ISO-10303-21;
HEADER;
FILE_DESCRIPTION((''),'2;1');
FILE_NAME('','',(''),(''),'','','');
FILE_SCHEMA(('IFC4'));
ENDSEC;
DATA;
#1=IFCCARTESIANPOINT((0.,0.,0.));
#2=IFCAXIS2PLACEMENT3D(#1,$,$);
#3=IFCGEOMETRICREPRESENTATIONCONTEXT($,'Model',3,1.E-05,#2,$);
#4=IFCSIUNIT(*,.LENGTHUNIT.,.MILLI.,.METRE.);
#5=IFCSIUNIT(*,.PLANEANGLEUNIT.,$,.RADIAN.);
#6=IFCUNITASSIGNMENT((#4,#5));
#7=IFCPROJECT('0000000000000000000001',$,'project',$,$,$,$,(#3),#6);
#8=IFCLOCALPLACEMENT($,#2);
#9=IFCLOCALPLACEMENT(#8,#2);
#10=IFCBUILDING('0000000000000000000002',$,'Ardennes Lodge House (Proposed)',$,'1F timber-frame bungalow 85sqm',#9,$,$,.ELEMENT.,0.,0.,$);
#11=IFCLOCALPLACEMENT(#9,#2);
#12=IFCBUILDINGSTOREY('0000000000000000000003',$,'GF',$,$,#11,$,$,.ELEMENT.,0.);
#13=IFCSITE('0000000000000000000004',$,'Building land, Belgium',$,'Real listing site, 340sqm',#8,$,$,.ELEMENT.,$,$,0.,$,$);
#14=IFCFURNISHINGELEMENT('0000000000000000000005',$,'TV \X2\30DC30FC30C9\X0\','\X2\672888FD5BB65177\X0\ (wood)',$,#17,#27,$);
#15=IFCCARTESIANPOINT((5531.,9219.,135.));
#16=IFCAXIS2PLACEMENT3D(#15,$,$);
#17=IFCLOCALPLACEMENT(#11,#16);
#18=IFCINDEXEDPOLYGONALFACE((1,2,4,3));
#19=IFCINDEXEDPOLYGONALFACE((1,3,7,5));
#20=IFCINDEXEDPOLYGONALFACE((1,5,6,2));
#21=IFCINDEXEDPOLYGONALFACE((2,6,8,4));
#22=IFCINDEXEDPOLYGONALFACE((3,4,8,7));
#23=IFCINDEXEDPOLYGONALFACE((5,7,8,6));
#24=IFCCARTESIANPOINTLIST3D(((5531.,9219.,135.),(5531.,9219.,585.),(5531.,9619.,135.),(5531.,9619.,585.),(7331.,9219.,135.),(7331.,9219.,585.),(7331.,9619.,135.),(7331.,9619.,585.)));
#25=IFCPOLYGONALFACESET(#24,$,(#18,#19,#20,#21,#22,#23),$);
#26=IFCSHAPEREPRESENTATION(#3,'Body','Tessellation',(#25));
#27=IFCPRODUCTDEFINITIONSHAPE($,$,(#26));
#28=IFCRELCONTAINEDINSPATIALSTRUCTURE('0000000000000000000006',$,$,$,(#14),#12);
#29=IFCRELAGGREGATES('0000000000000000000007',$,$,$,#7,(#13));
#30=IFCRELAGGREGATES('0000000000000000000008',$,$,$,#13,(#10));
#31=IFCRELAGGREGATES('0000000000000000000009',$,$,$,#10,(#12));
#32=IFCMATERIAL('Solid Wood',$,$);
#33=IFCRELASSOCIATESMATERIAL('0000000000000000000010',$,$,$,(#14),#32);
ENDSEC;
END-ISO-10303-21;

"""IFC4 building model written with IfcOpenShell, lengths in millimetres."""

from ifc_helpers import new_model, si_unit, frame, frame_2d, origin, place, context, project, spatial, rectangle, extrude, material, element, save


model = new_model("IFC4")

# Units and contexts
model_context = context("Model", 3, precision=1e-05, world=origin())
ifc_project = project(units=[si_unit("LENGTHUNIT", "METRE", prefix="MILLI"), si_unit("PLANEANGLEUNIT", "RADIAN")], contexts=[model_context])

# Site, building, storey
site_placement = place(None, origin())
site = spatial("IfcSite", under=ifc_project, at=site_placement, Name="Building land, Belgium", ObjectType="Real listing site, 340sqm", CompositionType="ELEMENT", RefElevation=0.0)
building_placement = place(site_placement, origin())
building = spatial("IfcBuilding", under=site, at=building_placement, Name="Ardennes Lodge House (Proposed)", ObjectType="1F timber-frame bungalow 85sqm", CompositionType="ELEMENT", ElevationOfRefHeight=0.0, ElevationOfTerrain=0.0)
storey_placement = place(building_placement, origin())
storey = spatial("IfcBuildingStorey", under=building, at=storey_placement, Name="GF", CompositionType="ELEMENT", Elevation=0.0)

# Shared definitions
ifc_material_1 = material(Name="Solid Wood")

# Furnishing element
furnishing_1_placement = place(storey_placement, frame((5531.0, 9219.0, 135.0)))
element("IfcFurnishingElement", 1, at=furnishing_1_placement, inside=storey, material=ifc_material_1, Name="TV ボード", Description="木製家具 (wood)", context=model_context, shape_type="SweptSolid", body=[
    extrude(rectangle(XDim=1800.0, YDim=400.0, at=frame_2d((900.0, 200.0))), frame((5531.0, 9219.0, 135.0)), (0.0, 0.0, 1.0), 450.0),
])

save(model, "model.ifc")
